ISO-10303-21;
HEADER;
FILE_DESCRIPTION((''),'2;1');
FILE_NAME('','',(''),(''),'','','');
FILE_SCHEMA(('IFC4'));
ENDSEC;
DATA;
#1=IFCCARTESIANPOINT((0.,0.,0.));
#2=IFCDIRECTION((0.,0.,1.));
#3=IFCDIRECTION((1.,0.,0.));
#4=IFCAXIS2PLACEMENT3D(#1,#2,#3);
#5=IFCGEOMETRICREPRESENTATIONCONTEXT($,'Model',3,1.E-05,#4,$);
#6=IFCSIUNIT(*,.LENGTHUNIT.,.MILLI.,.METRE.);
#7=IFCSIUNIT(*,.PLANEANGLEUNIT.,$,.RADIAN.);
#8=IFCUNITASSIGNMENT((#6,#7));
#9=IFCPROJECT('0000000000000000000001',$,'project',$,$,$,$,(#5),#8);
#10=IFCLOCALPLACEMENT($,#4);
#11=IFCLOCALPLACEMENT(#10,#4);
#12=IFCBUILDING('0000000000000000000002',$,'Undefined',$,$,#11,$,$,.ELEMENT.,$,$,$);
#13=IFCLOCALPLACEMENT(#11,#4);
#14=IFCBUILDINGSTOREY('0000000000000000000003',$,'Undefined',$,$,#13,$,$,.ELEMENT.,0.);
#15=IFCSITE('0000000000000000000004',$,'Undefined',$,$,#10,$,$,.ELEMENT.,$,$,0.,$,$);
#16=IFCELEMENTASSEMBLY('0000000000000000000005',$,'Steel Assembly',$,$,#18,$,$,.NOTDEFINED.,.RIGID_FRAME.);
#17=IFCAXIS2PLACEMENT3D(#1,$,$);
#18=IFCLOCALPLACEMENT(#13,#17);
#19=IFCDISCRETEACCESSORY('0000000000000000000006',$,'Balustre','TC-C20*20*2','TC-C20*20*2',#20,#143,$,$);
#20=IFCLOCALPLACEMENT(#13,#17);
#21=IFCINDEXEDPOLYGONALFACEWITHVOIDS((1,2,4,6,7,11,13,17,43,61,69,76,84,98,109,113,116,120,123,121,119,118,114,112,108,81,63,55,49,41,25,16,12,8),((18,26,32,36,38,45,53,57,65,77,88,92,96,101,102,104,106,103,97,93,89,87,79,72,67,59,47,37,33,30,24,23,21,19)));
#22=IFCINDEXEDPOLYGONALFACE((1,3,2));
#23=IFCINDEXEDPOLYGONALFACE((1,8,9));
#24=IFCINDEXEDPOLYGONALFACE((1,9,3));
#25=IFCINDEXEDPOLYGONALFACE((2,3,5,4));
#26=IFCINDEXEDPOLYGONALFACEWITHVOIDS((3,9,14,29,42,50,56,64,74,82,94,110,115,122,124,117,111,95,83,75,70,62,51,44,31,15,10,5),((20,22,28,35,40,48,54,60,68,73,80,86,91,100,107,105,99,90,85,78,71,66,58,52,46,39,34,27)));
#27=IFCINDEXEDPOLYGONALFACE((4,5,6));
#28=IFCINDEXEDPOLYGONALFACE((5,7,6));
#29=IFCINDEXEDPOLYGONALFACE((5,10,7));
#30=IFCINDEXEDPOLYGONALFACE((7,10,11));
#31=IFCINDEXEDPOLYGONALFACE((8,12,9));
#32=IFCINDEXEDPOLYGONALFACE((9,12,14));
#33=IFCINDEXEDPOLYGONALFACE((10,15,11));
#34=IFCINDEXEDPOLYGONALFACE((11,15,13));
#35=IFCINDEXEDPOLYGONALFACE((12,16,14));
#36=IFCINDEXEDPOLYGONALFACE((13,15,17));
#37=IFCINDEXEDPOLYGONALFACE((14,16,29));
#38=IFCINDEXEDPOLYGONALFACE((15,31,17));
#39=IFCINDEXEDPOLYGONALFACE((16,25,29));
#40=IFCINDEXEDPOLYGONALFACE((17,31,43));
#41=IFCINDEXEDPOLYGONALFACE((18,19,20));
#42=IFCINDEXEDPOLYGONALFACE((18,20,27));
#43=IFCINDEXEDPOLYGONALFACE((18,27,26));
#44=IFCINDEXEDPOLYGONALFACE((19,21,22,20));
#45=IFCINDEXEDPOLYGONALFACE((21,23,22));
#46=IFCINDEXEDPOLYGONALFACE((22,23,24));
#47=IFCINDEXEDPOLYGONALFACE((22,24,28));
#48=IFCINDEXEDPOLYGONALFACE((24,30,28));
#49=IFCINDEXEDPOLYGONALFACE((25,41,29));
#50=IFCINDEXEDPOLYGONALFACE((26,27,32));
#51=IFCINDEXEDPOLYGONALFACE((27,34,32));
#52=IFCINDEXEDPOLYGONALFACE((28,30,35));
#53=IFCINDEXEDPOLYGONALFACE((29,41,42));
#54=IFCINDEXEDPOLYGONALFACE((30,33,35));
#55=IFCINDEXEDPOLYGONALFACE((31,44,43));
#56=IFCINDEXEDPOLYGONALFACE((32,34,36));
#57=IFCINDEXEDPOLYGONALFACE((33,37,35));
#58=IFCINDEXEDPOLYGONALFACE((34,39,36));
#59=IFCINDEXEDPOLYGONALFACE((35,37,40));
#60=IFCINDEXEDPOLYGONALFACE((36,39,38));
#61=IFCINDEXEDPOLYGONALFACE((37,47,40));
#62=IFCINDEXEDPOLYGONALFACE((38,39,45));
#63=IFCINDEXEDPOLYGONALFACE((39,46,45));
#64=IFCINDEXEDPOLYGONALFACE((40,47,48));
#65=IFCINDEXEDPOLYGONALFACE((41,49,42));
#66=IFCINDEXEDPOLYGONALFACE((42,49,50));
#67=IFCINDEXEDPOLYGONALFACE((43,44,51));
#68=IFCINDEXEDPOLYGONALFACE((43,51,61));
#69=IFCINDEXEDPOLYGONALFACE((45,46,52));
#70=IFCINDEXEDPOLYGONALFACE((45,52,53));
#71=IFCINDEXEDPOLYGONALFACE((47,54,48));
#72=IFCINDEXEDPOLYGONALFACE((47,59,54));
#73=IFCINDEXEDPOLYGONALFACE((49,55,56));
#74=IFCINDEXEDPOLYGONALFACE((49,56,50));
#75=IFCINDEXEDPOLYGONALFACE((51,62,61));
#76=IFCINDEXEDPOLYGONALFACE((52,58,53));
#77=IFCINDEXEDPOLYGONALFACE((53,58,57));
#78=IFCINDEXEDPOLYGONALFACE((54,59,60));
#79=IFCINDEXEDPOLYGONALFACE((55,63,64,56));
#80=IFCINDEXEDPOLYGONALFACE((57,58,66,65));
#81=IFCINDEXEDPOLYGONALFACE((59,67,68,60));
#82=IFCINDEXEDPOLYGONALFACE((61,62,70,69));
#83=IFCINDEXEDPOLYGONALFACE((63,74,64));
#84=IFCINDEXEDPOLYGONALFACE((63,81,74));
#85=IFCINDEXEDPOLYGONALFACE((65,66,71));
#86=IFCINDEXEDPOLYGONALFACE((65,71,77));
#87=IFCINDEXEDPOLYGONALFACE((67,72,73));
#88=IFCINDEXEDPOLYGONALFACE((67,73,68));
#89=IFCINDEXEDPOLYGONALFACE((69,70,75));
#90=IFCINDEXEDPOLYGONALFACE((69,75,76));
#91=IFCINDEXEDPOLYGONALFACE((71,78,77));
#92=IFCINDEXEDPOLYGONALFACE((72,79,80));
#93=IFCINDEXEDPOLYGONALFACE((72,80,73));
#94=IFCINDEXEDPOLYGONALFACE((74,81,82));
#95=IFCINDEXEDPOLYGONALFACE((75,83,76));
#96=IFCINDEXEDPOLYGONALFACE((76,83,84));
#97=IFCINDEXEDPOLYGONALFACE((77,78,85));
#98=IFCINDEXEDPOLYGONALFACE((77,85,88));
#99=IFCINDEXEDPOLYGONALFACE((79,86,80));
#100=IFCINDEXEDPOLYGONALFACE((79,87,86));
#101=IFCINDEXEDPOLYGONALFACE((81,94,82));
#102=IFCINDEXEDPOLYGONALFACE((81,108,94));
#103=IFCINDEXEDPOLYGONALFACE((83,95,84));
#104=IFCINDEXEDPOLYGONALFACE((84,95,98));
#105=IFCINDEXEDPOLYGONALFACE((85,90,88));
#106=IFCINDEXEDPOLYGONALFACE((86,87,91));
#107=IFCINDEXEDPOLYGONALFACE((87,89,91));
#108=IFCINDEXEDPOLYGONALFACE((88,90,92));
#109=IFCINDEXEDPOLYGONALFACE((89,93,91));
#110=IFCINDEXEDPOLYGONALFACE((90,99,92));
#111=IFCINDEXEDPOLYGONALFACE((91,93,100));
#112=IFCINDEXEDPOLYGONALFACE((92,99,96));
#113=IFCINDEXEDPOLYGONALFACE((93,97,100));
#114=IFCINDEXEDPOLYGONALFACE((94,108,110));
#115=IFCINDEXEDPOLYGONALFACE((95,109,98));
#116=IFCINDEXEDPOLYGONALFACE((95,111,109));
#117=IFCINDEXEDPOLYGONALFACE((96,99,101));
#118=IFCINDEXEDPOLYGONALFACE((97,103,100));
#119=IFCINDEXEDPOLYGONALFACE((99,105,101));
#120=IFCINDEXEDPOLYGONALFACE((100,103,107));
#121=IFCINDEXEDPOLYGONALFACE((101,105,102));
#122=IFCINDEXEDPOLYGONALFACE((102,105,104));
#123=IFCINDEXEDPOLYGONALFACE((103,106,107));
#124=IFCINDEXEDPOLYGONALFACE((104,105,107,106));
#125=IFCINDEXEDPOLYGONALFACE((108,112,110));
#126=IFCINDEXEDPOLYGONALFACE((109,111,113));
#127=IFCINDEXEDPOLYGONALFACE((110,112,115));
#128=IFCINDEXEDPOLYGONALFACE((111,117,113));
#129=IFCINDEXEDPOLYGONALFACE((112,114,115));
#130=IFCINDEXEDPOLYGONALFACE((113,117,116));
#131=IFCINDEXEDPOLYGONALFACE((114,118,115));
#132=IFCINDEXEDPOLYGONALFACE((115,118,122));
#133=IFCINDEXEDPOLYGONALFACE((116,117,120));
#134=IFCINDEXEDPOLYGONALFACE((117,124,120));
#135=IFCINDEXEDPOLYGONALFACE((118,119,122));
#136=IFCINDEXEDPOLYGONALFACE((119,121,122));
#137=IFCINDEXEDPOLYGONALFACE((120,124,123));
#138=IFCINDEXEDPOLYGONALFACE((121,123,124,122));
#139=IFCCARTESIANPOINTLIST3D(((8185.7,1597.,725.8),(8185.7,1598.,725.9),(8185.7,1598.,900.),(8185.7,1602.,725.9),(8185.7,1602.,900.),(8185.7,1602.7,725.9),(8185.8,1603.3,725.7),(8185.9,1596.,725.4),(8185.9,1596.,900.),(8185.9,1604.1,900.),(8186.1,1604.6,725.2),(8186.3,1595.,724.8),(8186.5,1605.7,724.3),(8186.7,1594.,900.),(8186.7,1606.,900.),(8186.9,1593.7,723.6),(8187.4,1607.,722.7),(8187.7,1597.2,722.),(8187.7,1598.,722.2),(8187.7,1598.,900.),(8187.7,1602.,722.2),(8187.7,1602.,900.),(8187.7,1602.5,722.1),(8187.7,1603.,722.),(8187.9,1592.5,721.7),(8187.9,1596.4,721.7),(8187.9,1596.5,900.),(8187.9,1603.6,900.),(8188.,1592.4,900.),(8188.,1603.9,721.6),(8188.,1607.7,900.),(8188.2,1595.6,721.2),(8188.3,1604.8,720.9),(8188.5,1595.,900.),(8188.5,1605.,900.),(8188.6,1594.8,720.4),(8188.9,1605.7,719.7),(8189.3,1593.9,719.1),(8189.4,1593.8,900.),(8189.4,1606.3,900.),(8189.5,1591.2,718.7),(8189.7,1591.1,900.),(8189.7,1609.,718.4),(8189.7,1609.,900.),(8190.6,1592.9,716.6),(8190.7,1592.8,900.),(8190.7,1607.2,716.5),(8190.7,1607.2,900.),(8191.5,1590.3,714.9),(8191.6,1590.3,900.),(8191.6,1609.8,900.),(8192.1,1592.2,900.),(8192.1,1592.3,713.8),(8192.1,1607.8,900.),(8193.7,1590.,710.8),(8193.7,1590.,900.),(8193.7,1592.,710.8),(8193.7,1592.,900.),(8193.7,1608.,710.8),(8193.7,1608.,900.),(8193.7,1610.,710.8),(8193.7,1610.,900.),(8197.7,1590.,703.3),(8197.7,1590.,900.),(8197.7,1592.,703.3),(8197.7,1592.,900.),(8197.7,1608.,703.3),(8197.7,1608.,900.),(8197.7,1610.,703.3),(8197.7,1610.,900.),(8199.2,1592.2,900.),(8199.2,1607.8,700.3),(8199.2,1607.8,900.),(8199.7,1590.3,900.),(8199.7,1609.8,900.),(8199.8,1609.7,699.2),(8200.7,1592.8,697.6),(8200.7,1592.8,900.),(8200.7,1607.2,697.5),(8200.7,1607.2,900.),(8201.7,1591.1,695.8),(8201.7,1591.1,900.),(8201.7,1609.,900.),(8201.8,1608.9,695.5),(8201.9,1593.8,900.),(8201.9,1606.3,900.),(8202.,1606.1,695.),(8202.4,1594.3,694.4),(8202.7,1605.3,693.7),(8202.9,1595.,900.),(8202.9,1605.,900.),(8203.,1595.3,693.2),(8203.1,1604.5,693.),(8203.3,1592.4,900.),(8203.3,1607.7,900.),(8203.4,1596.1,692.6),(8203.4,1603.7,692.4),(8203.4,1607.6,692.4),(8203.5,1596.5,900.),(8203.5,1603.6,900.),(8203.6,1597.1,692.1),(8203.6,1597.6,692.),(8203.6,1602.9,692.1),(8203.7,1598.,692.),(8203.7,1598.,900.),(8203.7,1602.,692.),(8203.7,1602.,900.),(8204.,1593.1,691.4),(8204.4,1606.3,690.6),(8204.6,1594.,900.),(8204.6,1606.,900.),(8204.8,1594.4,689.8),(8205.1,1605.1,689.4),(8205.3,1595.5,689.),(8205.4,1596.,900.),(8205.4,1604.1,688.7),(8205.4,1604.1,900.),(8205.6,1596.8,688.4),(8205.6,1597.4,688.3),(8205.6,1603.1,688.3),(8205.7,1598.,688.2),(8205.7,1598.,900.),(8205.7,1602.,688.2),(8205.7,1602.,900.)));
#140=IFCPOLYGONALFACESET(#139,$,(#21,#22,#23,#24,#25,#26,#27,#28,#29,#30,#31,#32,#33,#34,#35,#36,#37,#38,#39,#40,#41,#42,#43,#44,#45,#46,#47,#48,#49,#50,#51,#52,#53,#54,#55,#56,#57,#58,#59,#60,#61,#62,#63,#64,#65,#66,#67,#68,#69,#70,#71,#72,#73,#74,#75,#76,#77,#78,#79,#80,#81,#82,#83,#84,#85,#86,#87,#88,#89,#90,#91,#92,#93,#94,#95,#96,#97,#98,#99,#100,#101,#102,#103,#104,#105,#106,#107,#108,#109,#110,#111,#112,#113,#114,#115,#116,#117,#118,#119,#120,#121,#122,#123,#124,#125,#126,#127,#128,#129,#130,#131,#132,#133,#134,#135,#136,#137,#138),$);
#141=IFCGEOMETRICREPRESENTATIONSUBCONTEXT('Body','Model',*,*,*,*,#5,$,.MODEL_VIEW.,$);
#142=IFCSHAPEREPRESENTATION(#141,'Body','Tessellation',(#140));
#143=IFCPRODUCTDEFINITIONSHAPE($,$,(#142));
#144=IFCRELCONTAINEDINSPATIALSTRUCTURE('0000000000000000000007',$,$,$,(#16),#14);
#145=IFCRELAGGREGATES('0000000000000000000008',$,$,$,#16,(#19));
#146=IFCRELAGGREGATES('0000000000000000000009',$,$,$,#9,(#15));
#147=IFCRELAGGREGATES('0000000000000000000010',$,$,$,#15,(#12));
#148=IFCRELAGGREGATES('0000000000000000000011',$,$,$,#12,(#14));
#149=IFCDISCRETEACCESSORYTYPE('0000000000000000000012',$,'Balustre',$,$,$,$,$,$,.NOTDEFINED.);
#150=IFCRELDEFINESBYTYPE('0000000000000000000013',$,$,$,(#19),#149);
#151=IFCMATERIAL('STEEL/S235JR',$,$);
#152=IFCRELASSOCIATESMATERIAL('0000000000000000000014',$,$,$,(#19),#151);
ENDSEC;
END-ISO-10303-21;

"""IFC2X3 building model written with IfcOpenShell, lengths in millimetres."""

from ifc_helpers import new_model, si_unit, frame, origin_with_axes, origin_2d_with_axis, place, context, subcontext, project, spatial, hollow_rectangle, extrude, clip, halfspace, material, type_object, element, aggregate, save


model = new_model("IFC2X3")

# Units and contexts
model_context = context("Model", 3, precision=1e-05, world=origin_with_axes())
body_context = subcontext(model_context, "Body", "Model", "MODEL_VIEW")
ifc_project = project(units=[si_unit("LENGTHUNIT", "METRE", prefix="MILLI"), si_unit("PLANEANGLEUNIT", "RADIAN")], contexts=[model_context])

# Site, building, storey
site_placement = place(None, origin_with_axes())
site = spatial("IfcSite", under=ifc_project, at=site_placement, Name="Undefined", CompositionType="ELEMENT", RefElevation=0.0)
building_placement = place(site_placement, origin_with_axes())
building = spatial("IfcBuilding", under=site, at=building_placement, Name="Undefined", CompositionType="ELEMENT")
storey_placement = place(building_placement, origin_with_axes())
storey = spatial("IfcBuildingStorey", under=building, at=storey_placement, Name="Undefined", CompositionType="ELEMENT", Elevation=0.0)

# Shared definitions
ifc_material = material(Name="STEEL/S235JR")

# Element assembly, discrete accessory
discrete_accessory_type_1 = type_object("IfcDiscreteAccessoryType", Name="Balustre")
assembly_1_placement = place(storey_placement, origin_with_axes())
assembly_1 = element("IfcElementAssembly", 1, at=assembly_1_placement, inside=storey, Name="Steel Assembly", AssemblyPlace="NOTDEFINED", PredefinedType="RIGID_FRAME")
discrete_accessory_1_placement = place(assembly_1_placement, frame((8195.7, 1600.0, 900.0), z_axis=(0.0, 1.0, 0.0), x_axis=(0.0, 0.0, -1.0)))
discrete_accessory_1 = element("IfcDiscreteAccessory", 2, at=discrete_accessory_1_placement, type_object=discrete_accessory_type_1, material=ifc_material, Name="Balustre", Description="TC-C20*20*2", ObjectType="TC-C20*20*2", context=body_context, shape_type="Clipping", body=[
    clip(extrude(hollow_rectangle(XDim=20.0, YDim=20.0, WallThickness=2.0, InnerFilletRadius=6.0, OuterFilletRadius=8.0, at=origin_2d_with_axis()), frame((212.0, 0.0, 0.0), z_axis=(-1.0, 0.0, 0.0), x_axis=(0.0, -1.0, 0.0)), (0.0, 0.0, 1.0), 212.0), halfspace(frame((150.3, 22.6, 0.0), z_axis=(-0.46842, -0.883506, 0.000005), x_axis=(0.0, 0.000005, 1.0)), True)),
])

aggregate(assembly_1, [discrete_accessory_1])

save(model, "model.ifc")
